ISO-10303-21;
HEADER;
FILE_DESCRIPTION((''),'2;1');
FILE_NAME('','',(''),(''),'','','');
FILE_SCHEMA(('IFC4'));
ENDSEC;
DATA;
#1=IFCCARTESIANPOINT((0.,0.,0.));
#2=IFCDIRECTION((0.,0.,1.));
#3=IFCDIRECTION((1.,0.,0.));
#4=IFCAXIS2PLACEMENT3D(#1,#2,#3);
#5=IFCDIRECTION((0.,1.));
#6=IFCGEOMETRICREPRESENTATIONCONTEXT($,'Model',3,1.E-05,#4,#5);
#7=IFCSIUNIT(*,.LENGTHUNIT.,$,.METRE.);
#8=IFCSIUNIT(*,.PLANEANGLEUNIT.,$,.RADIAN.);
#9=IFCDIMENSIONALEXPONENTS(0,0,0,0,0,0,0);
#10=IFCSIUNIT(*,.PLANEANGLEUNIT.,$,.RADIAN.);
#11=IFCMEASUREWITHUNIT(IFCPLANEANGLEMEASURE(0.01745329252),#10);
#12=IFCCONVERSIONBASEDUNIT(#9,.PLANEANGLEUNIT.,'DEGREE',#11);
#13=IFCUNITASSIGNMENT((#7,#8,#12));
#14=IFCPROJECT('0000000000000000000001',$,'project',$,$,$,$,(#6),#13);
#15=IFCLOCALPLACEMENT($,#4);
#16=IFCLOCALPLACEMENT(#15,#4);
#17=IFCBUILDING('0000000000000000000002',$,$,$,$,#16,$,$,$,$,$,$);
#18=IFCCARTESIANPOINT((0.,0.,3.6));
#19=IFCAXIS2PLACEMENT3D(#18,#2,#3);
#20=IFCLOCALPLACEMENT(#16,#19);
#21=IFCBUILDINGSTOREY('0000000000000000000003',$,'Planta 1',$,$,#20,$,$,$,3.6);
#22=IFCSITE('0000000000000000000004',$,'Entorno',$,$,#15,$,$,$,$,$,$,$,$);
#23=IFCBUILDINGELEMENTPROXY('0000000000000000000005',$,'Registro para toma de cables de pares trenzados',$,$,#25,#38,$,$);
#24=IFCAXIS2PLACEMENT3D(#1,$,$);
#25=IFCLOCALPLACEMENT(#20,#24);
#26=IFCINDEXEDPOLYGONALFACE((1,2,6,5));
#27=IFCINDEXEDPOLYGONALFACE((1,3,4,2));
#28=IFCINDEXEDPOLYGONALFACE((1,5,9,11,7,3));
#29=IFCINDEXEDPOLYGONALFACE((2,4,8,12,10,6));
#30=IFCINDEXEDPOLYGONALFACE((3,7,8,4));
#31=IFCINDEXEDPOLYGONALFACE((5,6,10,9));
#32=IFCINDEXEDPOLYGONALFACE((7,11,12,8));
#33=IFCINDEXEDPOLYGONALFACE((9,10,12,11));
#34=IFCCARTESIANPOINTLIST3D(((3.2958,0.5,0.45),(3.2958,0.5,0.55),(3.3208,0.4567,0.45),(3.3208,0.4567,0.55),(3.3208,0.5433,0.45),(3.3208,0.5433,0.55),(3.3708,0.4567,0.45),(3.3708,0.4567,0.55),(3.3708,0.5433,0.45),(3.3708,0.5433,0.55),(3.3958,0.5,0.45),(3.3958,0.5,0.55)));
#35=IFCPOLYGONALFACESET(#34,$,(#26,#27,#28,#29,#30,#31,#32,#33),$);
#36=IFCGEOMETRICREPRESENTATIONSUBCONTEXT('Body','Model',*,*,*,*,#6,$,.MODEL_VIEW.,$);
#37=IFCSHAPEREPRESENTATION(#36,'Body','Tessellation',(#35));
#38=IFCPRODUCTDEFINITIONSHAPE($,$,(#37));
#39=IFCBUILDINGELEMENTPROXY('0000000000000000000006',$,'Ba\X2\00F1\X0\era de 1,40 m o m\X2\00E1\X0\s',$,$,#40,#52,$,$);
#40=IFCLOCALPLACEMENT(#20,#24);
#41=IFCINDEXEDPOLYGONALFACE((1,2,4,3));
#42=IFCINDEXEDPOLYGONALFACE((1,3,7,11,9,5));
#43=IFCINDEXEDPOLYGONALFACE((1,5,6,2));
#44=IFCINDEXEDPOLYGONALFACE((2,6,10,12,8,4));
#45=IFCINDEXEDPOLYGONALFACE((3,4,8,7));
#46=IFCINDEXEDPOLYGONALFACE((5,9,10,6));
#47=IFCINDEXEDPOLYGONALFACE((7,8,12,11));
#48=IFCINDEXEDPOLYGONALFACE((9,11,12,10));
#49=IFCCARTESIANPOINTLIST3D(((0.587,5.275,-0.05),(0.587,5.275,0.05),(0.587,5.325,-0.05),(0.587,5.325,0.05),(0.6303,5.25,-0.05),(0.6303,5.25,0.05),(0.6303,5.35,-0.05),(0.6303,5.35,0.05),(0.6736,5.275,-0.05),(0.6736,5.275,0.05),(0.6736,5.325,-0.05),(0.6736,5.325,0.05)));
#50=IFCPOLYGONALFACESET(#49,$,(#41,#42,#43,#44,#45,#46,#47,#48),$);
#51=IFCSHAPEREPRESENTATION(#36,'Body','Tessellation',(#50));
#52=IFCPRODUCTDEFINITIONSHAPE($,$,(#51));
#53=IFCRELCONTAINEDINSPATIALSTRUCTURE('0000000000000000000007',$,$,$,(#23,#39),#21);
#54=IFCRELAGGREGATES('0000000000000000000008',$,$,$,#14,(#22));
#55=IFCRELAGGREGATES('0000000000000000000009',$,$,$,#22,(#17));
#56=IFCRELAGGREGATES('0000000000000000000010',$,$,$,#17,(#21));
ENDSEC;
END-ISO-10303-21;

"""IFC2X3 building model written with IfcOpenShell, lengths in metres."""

from ifc_helpers import new_model, entity, si_unit, converted_unit, direction, frame, origin_with_axes, place, context, subcontext, project, spatial, polyline, outline, extrude, source, transform, mapped, element, save


model = new_model("IFC2X3")

# Units and contexts
model_context = context("Model", 3, precision=1e-05, world=origin_with_axes(), true_north=direction((0.0, 1.0)))
body_context = subcontext(model_context, "Body", "Model", "MODEL_VIEW")
ifc_project = project(units=[si_unit("LENGTHUNIT", "METRE"), si_unit("PLANEANGLEUNIT", "RADIAN"), converted_unit("PLANEANGLEUNIT", "DEGREE", entity("IfcPlaneAngleMeasure", 0.01745329252), si_unit("PLANEANGLEUNIT", "RADIAN"), dimensions=[0, 0, 0, 0, 0, 0, 0])], contexts=[model_context])

# Site, building, storey
site_placement = place(None, origin_with_axes())
site = spatial("IfcSite", under=ifc_project, at=site_placement, Name="Entorno")
building_placement = place(site_placement, origin_with_axes())
building = spatial("IfcBuilding", under=site, at=building_placement)
storey_placement = place(building_placement, frame((0.0, 0.0, 3.6), z_axis=(0.0, 0.0, 1.0), x_axis=(1.0, 0.0, 0.0)))
storey = spatial("IfcBuildingStorey", under=building, at=storey_placement, Name="Planta 1", Elevation=3.6)

# Building element proxies
shared_shape_1 = source(origin_with_axes(), body_context, "Body", "SolidModel", [
    extrude(outline(polyline([(0.05, 0.0), (0.025, 0.0433), (-0.025, 0.0433), (-0.05, 0.0), (-0.025, -0.0433), (0.025, -0.0433), (0.05, 0.0)])), frame((0.0, 0.0, -0.05), z_axis=(0.0, 0.0, 1.0), x_axis=(1.0, 0.0, 0.0)), (0.0, 0.0, 1.0), 0.1),
])
proxy_1_placement = place(storey_placement, frame((0.0, 0.0, -3.6), z_axis=(0.0, 0.0, 1.0), x_axis=(1.0, 0.0, 0.0)))
element("IfcBuildingElementProxy", 1, at=proxy_1_placement, inside=storey, Name="Registro para toma de cables de pares trenzados", context=body_context, shape_type="Brep", body=[
    mapped(shared_shape_1, transform((3.3458, 0.5, 4.1), x_axis=(1.0, 0.0, 0.0), y_axis=(0.0, 1.0, 0.0), z_axis=(0.0, 0.0, 1.0))),
])
shared_shape_2 = source(origin_with_axes(), body_context, "Body", "SolidModel", [
    extrude(outline(polyline([(0.05, 0.0), (0.025, 0.0433), (-0.025, 0.0433), (-0.05, 0.0), (-0.025, -0.0433), (0.025, -0.0433), (0.05, 0.0)])), frame((0.0, 0.0, -0.05), z_axis=(0.0, 0.0, 1.0), x_axis=(1.0, 0.0, 0.0)), (0.0, 0.0, 1.0), 0.1),
])
proxy_2_placement = place(storey_placement, frame((0.0, 0.0, -3.6), z_axis=(0.0, 0.0, 1.0), x_axis=(1.0, 0.0, 0.0)))
element("IfcBuildingElementProxy", 2, at=proxy_2_placement, inside=storey, Name="Bañera de 1,40 m o más", context=body_context, shape_type="Brep", body=[
    mapped(shared_shape_2, transform((0.6303, 5.3, 3.6), x_axis=(0.0, -1.0, 0.0), y_axis=(1.0, 0.0, 0.0), z_axis=(0.0, 0.0, 1.0))),
])

save(model, "model.ifc")
